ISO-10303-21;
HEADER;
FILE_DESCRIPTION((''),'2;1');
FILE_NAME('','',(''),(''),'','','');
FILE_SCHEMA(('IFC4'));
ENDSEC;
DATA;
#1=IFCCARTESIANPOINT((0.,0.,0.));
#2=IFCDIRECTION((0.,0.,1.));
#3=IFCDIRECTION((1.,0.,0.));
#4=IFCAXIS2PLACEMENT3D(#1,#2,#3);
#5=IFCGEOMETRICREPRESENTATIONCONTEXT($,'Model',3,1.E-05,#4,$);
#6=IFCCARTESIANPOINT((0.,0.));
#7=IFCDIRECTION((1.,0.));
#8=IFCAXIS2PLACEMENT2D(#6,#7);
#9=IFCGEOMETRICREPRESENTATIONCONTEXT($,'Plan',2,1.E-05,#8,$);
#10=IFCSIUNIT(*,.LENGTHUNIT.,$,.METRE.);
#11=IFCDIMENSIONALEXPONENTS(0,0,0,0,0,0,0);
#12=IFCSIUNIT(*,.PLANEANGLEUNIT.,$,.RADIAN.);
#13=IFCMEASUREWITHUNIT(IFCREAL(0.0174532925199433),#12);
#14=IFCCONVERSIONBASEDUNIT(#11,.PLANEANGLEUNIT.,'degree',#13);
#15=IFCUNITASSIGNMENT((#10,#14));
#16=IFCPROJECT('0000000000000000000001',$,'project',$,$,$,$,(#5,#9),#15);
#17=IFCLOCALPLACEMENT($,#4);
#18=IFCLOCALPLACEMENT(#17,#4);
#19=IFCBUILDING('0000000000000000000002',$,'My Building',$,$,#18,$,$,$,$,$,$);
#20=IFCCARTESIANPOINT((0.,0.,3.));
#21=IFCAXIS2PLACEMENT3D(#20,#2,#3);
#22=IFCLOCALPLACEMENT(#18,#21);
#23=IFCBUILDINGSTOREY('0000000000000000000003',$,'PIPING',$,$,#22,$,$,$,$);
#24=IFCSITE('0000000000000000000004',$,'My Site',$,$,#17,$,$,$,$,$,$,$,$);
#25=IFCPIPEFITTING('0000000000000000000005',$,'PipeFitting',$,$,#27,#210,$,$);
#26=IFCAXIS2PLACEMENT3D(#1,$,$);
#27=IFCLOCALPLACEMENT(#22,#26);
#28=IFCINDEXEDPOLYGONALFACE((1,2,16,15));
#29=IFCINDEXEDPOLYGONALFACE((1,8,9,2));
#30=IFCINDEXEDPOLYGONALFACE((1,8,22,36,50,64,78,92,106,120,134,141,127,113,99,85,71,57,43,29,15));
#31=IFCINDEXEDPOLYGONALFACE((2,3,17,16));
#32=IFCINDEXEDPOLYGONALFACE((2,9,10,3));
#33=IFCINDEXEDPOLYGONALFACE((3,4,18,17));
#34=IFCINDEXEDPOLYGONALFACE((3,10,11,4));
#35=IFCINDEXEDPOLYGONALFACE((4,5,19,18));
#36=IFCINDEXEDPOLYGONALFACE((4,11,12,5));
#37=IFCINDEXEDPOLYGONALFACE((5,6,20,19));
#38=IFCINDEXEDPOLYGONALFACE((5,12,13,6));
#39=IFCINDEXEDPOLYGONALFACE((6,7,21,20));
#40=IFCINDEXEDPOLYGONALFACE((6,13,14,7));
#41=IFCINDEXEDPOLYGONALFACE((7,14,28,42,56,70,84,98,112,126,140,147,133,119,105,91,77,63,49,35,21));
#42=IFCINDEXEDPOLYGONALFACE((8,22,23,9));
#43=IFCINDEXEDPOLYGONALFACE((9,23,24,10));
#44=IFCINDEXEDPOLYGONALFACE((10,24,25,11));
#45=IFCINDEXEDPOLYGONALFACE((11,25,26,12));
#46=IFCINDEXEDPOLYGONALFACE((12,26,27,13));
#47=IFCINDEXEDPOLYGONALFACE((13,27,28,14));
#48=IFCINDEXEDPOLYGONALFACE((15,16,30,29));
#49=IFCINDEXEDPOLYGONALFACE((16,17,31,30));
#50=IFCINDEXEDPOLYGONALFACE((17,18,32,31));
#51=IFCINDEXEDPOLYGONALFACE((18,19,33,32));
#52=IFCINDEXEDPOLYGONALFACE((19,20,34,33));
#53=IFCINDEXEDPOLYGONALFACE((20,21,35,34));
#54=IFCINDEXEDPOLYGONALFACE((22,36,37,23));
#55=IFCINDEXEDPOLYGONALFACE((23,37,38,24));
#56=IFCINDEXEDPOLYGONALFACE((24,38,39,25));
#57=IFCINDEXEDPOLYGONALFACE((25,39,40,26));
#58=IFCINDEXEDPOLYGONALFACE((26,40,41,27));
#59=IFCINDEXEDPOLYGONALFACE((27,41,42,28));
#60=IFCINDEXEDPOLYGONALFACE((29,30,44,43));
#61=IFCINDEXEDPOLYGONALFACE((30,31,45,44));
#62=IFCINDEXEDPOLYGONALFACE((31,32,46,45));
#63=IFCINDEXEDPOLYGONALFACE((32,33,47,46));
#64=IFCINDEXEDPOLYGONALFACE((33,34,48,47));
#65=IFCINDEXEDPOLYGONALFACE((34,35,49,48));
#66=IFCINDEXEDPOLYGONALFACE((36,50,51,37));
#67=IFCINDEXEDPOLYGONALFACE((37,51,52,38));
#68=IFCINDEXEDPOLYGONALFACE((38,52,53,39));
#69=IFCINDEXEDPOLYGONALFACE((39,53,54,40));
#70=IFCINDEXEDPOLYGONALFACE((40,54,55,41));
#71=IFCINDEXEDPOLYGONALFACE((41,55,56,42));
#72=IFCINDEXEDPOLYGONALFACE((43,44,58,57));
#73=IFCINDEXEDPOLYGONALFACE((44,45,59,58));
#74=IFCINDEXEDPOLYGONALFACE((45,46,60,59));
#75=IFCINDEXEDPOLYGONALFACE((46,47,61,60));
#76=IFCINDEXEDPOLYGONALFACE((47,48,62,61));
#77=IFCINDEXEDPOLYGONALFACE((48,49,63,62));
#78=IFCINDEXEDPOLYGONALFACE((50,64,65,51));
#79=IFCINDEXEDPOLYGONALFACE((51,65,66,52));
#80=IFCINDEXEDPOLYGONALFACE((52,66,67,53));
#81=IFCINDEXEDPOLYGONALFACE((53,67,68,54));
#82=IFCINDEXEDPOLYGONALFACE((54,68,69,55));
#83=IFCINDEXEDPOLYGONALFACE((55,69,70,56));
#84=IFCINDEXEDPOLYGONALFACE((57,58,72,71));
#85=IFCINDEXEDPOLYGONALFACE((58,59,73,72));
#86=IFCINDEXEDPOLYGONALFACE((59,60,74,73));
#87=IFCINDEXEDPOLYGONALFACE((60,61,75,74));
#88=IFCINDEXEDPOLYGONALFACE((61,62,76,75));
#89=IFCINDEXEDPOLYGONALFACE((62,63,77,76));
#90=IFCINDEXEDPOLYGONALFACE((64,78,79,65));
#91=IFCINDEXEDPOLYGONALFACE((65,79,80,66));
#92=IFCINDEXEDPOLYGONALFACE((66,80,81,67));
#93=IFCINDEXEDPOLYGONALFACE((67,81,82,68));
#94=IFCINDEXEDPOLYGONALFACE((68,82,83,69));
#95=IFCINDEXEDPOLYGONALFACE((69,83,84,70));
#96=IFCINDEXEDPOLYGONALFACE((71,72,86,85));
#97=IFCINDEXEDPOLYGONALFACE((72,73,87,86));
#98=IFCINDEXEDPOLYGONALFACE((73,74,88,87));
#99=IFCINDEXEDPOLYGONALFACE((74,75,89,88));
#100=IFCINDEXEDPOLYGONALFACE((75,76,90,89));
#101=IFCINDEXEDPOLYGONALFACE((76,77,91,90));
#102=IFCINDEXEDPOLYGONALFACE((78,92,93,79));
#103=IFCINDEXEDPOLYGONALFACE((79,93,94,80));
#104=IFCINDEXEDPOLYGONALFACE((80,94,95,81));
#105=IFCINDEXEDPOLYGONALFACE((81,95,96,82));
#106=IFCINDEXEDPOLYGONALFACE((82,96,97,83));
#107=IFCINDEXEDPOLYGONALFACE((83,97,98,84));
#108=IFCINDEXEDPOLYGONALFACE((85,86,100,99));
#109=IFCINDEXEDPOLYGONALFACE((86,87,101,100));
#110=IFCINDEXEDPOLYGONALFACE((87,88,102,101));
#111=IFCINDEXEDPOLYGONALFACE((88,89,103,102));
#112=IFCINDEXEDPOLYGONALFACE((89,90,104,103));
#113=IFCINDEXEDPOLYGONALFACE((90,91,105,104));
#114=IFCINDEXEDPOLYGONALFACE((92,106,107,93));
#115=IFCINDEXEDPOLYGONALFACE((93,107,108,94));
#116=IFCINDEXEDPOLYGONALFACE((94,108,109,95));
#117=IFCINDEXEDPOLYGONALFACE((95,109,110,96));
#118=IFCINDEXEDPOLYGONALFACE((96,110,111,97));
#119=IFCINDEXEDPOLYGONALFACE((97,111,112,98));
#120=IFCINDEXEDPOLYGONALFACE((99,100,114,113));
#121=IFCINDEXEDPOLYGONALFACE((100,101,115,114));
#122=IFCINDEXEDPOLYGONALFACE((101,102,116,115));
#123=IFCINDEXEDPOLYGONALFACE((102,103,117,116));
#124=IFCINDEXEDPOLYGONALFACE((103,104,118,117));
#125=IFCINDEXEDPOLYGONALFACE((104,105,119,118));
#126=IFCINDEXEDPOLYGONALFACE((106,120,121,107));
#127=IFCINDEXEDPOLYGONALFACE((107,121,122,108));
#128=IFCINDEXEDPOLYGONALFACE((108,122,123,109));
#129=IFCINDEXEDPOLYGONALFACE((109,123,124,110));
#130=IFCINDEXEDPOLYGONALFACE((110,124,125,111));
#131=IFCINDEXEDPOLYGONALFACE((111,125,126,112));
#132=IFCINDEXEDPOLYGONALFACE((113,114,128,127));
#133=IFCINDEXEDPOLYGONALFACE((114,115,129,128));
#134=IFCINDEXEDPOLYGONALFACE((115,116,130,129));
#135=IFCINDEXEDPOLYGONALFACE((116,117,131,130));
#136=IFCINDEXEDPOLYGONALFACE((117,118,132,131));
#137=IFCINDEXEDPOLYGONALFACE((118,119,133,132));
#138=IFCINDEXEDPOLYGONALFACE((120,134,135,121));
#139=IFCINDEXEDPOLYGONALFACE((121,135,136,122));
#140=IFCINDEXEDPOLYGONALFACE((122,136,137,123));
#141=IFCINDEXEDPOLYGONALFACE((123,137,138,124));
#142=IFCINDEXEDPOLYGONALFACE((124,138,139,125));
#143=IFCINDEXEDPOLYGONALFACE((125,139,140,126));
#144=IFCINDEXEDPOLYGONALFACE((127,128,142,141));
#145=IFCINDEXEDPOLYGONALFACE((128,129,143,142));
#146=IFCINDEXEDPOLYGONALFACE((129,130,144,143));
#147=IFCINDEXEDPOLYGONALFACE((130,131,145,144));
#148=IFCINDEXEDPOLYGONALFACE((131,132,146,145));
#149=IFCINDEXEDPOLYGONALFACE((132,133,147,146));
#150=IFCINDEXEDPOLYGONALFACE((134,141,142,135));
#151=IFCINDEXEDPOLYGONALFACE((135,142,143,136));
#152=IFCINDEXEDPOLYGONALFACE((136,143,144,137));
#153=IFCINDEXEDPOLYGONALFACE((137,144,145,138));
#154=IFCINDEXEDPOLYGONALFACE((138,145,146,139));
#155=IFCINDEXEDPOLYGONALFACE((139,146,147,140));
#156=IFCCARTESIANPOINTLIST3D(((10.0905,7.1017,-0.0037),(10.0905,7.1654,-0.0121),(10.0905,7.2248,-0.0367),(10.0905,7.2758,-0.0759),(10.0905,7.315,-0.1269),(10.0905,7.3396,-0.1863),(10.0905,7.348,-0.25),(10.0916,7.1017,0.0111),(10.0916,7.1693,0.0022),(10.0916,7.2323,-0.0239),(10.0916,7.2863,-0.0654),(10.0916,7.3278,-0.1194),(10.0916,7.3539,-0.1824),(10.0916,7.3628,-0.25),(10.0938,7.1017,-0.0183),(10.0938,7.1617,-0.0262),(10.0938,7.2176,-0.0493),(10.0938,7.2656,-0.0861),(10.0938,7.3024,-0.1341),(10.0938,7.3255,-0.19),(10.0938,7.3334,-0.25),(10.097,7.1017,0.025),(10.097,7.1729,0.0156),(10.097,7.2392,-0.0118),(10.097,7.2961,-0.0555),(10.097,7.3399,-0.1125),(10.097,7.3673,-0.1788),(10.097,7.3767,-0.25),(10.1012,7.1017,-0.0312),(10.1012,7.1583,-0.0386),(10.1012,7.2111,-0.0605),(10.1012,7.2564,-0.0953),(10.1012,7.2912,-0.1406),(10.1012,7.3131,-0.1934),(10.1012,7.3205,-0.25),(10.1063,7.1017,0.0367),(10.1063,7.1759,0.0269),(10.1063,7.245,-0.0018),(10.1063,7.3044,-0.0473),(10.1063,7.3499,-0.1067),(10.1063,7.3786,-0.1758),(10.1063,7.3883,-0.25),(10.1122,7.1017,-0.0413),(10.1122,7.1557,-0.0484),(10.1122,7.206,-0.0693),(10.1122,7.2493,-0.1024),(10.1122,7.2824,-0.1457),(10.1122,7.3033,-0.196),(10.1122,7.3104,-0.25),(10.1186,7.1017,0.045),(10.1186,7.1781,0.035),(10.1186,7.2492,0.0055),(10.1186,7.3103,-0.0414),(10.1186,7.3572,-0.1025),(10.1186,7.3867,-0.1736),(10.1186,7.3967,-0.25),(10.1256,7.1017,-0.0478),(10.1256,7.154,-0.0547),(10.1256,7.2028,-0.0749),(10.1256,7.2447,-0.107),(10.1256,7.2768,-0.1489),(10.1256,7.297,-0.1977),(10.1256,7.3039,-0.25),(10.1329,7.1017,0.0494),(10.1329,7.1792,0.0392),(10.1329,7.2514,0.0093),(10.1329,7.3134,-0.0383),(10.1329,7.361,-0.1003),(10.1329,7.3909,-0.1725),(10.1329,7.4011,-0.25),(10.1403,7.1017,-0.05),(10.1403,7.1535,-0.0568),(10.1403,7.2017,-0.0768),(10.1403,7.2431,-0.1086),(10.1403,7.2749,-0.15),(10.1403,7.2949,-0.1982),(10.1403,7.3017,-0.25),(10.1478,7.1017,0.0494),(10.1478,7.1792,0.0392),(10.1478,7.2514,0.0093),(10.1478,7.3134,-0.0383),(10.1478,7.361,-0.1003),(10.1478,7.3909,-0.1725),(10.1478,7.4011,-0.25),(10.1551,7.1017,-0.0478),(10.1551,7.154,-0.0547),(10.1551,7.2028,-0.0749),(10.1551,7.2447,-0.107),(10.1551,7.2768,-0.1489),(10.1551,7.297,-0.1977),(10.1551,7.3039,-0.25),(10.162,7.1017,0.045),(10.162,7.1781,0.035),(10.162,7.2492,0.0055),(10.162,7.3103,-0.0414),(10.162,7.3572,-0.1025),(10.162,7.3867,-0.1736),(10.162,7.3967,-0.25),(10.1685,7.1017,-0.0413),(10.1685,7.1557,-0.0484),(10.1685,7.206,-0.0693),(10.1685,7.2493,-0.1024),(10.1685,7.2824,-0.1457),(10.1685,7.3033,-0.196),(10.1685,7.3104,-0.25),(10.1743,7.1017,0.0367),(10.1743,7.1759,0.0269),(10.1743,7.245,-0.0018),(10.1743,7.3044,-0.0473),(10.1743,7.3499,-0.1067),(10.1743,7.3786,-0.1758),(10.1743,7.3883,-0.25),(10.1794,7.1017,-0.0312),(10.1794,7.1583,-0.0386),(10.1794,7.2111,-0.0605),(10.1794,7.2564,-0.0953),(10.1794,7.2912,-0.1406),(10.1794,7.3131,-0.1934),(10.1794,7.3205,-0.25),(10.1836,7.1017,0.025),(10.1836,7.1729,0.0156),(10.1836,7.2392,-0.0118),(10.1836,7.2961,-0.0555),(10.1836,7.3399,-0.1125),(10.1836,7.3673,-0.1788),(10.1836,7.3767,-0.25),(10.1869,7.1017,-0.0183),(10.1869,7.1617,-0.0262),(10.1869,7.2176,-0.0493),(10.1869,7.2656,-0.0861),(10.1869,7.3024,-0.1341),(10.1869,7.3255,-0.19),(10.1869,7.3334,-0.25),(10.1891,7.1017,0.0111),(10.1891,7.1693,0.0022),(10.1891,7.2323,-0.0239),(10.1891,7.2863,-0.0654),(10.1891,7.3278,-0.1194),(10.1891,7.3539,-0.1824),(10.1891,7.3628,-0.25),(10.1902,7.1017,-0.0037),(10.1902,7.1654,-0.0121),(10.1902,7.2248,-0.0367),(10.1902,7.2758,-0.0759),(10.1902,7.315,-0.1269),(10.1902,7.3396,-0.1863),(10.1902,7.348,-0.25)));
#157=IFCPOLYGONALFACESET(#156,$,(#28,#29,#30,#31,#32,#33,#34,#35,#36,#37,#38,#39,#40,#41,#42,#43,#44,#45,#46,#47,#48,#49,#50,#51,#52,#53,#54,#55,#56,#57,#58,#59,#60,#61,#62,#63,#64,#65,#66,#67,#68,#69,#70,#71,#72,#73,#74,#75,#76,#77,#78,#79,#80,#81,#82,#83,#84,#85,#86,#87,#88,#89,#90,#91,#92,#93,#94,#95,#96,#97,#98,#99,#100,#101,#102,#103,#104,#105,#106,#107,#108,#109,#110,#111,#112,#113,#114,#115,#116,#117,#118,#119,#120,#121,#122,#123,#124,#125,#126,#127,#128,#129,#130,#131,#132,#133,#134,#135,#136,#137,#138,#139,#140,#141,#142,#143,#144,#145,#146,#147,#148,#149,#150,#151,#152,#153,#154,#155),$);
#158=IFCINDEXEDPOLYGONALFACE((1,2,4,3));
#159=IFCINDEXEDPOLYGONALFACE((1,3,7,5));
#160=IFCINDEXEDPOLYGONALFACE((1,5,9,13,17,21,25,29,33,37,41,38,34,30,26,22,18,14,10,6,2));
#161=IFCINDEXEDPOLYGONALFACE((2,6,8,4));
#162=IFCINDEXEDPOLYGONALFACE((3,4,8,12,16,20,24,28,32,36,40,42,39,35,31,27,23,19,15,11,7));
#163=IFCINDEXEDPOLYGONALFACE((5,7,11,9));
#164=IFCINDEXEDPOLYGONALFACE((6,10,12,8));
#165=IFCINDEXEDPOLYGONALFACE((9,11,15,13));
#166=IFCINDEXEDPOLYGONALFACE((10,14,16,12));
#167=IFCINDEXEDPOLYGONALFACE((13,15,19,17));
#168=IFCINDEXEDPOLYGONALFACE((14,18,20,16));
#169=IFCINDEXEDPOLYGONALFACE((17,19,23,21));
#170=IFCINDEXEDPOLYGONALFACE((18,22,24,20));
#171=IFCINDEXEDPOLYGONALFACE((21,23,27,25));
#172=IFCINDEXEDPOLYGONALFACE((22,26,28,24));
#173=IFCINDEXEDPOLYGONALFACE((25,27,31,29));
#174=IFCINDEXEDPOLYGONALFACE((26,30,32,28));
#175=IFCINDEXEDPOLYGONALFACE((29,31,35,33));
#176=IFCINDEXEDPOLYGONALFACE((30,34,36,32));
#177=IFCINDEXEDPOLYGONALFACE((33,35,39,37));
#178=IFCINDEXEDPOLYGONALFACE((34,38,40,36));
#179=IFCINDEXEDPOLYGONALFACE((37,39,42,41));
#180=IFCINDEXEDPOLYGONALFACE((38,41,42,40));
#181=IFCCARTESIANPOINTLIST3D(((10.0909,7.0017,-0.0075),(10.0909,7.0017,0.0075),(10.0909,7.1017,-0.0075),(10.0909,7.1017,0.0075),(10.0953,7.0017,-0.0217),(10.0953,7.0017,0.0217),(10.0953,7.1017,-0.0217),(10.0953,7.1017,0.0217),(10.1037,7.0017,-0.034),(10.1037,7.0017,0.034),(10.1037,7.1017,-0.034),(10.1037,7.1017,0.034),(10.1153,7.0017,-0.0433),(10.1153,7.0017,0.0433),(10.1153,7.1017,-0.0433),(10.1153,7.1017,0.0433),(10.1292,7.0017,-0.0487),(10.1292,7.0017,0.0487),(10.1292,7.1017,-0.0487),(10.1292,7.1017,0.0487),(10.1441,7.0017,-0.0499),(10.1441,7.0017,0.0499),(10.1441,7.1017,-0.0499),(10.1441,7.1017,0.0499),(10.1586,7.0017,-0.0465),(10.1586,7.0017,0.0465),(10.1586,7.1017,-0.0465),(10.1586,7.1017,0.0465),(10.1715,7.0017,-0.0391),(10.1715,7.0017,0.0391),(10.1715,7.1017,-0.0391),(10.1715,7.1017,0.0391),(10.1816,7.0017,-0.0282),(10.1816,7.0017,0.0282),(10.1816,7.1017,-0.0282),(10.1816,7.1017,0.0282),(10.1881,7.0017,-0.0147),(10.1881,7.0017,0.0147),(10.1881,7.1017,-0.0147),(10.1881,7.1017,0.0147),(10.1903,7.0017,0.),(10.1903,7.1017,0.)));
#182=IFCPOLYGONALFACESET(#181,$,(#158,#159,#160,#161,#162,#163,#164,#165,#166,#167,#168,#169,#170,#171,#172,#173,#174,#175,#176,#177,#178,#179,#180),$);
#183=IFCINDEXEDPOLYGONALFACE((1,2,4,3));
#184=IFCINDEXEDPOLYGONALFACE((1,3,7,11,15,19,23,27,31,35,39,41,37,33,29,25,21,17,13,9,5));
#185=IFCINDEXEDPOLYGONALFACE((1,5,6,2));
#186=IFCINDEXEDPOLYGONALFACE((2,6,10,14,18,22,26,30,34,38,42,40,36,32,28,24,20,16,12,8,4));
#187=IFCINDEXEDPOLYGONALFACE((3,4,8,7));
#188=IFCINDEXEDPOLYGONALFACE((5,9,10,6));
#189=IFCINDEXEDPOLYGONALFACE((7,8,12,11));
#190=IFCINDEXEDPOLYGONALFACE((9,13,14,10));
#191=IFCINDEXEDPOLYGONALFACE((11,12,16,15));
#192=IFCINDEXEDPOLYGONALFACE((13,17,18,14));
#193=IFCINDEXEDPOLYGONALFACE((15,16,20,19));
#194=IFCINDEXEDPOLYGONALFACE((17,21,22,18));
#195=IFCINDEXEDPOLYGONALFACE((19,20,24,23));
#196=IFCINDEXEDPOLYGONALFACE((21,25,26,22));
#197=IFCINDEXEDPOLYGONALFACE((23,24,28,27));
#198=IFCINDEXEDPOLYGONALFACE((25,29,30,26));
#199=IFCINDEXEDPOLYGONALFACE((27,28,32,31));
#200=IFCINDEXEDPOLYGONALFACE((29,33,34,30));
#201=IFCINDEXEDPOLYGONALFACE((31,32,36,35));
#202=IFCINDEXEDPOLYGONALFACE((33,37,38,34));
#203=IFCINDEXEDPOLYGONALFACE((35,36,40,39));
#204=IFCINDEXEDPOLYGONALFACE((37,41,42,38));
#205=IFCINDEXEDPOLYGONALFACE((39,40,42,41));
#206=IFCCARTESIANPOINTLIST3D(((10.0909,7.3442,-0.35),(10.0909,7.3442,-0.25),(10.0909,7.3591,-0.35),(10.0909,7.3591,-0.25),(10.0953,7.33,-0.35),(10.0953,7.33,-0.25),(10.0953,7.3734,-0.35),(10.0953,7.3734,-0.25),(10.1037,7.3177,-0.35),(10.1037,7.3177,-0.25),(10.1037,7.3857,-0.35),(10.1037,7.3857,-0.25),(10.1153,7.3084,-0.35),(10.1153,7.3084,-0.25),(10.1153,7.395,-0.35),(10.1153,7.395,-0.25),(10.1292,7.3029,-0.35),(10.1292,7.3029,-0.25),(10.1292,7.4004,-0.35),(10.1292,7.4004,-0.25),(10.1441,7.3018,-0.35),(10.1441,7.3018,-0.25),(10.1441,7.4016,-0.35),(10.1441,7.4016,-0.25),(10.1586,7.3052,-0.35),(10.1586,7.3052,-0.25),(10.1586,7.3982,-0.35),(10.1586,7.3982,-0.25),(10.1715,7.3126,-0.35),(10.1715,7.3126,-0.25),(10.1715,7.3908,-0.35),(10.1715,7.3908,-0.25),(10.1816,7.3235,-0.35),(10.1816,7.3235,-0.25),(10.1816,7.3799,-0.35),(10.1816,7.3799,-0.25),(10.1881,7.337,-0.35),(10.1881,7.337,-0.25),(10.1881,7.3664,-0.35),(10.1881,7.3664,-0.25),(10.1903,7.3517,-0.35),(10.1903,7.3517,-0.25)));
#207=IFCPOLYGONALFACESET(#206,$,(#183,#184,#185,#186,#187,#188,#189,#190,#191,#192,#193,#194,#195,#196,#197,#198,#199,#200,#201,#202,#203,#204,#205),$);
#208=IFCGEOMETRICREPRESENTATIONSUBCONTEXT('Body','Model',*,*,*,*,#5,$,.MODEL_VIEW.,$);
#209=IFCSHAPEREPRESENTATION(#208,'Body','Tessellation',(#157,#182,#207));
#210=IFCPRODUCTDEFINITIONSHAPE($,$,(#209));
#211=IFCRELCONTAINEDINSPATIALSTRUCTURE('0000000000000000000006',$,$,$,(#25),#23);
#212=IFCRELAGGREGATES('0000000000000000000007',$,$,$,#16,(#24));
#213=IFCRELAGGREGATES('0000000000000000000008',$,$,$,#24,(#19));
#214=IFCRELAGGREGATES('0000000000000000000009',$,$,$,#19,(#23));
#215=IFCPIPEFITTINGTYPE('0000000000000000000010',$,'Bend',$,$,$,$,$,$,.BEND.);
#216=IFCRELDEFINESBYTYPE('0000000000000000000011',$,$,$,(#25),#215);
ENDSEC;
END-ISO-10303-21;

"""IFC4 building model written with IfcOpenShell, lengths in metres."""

from ifc_helpers import new_model, entity, si_unit, converted_unit, frame, origin_with_axes, origin_2d_with_axis, place, context, subcontext, project, spatial, circle, extrude, source, transform, mapped, type_object, type_shapes, element, save


model = new_model("IFC4")

# Units and contexts
model_context = context("Model", 3, precision=1e-05, world=origin_with_axes())
plan_context = context("Plan", 2, precision=1e-05, world=origin_2d_with_axis())
body_context = subcontext(model_context, "Body", "Model", "MODEL_VIEW")
ifc_project = project(units=[si_unit("LENGTHUNIT", "METRE"), converted_unit("PLANEANGLEUNIT", "degree", entity("IfcReal", 0.0174532925199433), si_unit("PLANEANGLEUNIT", "RADIAN"), dimensions=[0, 0, 0, 0, 0, 0, 0])], contexts=[model_context, plan_context])

# Site, building, storey
site_placement = place(None, origin_with_axes())
site = spatial("IfcSite", under=ifc_project, at=site_placement, Name="My Site")
building_placement = place(site_placement, origin_with_axes())
building = spatial("IfcBuilding", under=site, at=building_placement, Name="My Building")
storey_placement = place(building_placement, frame((0.0, 0.0, 3.0), z_axis=(0.0, 0.0, 1.0), x_axis=(1.0, 0.0, 0.0)))
storey = spatial("IfcBuildingStorey", under=building, at=storey_placement, Name="PIPING")

# Pipe fitting
pipe_fitting_type = type_object("IfcPipeFittingType", Name="Bend", PredefinedType="BEND")
shared_shape = source(origin_with_axes(), body_context, "Body", "SolidModel", [
    entity("IfcSweptDiskSolid", entity("IfcIndexedPolyCurve", entity("IfcCartesianPointList3D", [[0.0, 0.0, -0.1], [0.0, -0.0732, -0.2768], [0.0, -0.25, -0.35]]), [entity("IfcArcIndex", [1, 2, 3])]), 0.05),
    extrude(circle(Radius=0.05), origin_with_axes(), (0.0, 0.0, -1.0), 0.1),
    extrude(circle(Radius=0.05), frame((0.0, -0.25, -0.35), z_axis=(0.0, -1.0, 0.0), x_axis=(1.0, 0.0, 0.0)), (0.0, 0.0, 1.0), 0.1),
])
type_shapes(pipe_fitting_type, [shared_shape])
for number, where, z_axis, x_axis, name in (
    (1, (10.1403, 7.0017, 0.0), (0.0, -1.0, 0.0), (1.0, 0.0, 0.0), "PipeFitting"),
):
    element("IfcPipeFitting", number, at=place(storey_placement, frame(where, z_axis=z_axis, x_axis=x_axis)), inside=storey, type_object=pipe_fitting_type, Name=name, context=body_context, shape_type="MappedRepresentation", body=[
        mapped(shared_shape, transform((0.0, 0.0, 0.0), x_axis=(1.0, 0.0, 0.0), y_axis=(0.0, 1.0, 0.0), z_axis=(0.0, 0.0, 1.0), scale=1.0)),
    ])

save(model, "model.ifc")
